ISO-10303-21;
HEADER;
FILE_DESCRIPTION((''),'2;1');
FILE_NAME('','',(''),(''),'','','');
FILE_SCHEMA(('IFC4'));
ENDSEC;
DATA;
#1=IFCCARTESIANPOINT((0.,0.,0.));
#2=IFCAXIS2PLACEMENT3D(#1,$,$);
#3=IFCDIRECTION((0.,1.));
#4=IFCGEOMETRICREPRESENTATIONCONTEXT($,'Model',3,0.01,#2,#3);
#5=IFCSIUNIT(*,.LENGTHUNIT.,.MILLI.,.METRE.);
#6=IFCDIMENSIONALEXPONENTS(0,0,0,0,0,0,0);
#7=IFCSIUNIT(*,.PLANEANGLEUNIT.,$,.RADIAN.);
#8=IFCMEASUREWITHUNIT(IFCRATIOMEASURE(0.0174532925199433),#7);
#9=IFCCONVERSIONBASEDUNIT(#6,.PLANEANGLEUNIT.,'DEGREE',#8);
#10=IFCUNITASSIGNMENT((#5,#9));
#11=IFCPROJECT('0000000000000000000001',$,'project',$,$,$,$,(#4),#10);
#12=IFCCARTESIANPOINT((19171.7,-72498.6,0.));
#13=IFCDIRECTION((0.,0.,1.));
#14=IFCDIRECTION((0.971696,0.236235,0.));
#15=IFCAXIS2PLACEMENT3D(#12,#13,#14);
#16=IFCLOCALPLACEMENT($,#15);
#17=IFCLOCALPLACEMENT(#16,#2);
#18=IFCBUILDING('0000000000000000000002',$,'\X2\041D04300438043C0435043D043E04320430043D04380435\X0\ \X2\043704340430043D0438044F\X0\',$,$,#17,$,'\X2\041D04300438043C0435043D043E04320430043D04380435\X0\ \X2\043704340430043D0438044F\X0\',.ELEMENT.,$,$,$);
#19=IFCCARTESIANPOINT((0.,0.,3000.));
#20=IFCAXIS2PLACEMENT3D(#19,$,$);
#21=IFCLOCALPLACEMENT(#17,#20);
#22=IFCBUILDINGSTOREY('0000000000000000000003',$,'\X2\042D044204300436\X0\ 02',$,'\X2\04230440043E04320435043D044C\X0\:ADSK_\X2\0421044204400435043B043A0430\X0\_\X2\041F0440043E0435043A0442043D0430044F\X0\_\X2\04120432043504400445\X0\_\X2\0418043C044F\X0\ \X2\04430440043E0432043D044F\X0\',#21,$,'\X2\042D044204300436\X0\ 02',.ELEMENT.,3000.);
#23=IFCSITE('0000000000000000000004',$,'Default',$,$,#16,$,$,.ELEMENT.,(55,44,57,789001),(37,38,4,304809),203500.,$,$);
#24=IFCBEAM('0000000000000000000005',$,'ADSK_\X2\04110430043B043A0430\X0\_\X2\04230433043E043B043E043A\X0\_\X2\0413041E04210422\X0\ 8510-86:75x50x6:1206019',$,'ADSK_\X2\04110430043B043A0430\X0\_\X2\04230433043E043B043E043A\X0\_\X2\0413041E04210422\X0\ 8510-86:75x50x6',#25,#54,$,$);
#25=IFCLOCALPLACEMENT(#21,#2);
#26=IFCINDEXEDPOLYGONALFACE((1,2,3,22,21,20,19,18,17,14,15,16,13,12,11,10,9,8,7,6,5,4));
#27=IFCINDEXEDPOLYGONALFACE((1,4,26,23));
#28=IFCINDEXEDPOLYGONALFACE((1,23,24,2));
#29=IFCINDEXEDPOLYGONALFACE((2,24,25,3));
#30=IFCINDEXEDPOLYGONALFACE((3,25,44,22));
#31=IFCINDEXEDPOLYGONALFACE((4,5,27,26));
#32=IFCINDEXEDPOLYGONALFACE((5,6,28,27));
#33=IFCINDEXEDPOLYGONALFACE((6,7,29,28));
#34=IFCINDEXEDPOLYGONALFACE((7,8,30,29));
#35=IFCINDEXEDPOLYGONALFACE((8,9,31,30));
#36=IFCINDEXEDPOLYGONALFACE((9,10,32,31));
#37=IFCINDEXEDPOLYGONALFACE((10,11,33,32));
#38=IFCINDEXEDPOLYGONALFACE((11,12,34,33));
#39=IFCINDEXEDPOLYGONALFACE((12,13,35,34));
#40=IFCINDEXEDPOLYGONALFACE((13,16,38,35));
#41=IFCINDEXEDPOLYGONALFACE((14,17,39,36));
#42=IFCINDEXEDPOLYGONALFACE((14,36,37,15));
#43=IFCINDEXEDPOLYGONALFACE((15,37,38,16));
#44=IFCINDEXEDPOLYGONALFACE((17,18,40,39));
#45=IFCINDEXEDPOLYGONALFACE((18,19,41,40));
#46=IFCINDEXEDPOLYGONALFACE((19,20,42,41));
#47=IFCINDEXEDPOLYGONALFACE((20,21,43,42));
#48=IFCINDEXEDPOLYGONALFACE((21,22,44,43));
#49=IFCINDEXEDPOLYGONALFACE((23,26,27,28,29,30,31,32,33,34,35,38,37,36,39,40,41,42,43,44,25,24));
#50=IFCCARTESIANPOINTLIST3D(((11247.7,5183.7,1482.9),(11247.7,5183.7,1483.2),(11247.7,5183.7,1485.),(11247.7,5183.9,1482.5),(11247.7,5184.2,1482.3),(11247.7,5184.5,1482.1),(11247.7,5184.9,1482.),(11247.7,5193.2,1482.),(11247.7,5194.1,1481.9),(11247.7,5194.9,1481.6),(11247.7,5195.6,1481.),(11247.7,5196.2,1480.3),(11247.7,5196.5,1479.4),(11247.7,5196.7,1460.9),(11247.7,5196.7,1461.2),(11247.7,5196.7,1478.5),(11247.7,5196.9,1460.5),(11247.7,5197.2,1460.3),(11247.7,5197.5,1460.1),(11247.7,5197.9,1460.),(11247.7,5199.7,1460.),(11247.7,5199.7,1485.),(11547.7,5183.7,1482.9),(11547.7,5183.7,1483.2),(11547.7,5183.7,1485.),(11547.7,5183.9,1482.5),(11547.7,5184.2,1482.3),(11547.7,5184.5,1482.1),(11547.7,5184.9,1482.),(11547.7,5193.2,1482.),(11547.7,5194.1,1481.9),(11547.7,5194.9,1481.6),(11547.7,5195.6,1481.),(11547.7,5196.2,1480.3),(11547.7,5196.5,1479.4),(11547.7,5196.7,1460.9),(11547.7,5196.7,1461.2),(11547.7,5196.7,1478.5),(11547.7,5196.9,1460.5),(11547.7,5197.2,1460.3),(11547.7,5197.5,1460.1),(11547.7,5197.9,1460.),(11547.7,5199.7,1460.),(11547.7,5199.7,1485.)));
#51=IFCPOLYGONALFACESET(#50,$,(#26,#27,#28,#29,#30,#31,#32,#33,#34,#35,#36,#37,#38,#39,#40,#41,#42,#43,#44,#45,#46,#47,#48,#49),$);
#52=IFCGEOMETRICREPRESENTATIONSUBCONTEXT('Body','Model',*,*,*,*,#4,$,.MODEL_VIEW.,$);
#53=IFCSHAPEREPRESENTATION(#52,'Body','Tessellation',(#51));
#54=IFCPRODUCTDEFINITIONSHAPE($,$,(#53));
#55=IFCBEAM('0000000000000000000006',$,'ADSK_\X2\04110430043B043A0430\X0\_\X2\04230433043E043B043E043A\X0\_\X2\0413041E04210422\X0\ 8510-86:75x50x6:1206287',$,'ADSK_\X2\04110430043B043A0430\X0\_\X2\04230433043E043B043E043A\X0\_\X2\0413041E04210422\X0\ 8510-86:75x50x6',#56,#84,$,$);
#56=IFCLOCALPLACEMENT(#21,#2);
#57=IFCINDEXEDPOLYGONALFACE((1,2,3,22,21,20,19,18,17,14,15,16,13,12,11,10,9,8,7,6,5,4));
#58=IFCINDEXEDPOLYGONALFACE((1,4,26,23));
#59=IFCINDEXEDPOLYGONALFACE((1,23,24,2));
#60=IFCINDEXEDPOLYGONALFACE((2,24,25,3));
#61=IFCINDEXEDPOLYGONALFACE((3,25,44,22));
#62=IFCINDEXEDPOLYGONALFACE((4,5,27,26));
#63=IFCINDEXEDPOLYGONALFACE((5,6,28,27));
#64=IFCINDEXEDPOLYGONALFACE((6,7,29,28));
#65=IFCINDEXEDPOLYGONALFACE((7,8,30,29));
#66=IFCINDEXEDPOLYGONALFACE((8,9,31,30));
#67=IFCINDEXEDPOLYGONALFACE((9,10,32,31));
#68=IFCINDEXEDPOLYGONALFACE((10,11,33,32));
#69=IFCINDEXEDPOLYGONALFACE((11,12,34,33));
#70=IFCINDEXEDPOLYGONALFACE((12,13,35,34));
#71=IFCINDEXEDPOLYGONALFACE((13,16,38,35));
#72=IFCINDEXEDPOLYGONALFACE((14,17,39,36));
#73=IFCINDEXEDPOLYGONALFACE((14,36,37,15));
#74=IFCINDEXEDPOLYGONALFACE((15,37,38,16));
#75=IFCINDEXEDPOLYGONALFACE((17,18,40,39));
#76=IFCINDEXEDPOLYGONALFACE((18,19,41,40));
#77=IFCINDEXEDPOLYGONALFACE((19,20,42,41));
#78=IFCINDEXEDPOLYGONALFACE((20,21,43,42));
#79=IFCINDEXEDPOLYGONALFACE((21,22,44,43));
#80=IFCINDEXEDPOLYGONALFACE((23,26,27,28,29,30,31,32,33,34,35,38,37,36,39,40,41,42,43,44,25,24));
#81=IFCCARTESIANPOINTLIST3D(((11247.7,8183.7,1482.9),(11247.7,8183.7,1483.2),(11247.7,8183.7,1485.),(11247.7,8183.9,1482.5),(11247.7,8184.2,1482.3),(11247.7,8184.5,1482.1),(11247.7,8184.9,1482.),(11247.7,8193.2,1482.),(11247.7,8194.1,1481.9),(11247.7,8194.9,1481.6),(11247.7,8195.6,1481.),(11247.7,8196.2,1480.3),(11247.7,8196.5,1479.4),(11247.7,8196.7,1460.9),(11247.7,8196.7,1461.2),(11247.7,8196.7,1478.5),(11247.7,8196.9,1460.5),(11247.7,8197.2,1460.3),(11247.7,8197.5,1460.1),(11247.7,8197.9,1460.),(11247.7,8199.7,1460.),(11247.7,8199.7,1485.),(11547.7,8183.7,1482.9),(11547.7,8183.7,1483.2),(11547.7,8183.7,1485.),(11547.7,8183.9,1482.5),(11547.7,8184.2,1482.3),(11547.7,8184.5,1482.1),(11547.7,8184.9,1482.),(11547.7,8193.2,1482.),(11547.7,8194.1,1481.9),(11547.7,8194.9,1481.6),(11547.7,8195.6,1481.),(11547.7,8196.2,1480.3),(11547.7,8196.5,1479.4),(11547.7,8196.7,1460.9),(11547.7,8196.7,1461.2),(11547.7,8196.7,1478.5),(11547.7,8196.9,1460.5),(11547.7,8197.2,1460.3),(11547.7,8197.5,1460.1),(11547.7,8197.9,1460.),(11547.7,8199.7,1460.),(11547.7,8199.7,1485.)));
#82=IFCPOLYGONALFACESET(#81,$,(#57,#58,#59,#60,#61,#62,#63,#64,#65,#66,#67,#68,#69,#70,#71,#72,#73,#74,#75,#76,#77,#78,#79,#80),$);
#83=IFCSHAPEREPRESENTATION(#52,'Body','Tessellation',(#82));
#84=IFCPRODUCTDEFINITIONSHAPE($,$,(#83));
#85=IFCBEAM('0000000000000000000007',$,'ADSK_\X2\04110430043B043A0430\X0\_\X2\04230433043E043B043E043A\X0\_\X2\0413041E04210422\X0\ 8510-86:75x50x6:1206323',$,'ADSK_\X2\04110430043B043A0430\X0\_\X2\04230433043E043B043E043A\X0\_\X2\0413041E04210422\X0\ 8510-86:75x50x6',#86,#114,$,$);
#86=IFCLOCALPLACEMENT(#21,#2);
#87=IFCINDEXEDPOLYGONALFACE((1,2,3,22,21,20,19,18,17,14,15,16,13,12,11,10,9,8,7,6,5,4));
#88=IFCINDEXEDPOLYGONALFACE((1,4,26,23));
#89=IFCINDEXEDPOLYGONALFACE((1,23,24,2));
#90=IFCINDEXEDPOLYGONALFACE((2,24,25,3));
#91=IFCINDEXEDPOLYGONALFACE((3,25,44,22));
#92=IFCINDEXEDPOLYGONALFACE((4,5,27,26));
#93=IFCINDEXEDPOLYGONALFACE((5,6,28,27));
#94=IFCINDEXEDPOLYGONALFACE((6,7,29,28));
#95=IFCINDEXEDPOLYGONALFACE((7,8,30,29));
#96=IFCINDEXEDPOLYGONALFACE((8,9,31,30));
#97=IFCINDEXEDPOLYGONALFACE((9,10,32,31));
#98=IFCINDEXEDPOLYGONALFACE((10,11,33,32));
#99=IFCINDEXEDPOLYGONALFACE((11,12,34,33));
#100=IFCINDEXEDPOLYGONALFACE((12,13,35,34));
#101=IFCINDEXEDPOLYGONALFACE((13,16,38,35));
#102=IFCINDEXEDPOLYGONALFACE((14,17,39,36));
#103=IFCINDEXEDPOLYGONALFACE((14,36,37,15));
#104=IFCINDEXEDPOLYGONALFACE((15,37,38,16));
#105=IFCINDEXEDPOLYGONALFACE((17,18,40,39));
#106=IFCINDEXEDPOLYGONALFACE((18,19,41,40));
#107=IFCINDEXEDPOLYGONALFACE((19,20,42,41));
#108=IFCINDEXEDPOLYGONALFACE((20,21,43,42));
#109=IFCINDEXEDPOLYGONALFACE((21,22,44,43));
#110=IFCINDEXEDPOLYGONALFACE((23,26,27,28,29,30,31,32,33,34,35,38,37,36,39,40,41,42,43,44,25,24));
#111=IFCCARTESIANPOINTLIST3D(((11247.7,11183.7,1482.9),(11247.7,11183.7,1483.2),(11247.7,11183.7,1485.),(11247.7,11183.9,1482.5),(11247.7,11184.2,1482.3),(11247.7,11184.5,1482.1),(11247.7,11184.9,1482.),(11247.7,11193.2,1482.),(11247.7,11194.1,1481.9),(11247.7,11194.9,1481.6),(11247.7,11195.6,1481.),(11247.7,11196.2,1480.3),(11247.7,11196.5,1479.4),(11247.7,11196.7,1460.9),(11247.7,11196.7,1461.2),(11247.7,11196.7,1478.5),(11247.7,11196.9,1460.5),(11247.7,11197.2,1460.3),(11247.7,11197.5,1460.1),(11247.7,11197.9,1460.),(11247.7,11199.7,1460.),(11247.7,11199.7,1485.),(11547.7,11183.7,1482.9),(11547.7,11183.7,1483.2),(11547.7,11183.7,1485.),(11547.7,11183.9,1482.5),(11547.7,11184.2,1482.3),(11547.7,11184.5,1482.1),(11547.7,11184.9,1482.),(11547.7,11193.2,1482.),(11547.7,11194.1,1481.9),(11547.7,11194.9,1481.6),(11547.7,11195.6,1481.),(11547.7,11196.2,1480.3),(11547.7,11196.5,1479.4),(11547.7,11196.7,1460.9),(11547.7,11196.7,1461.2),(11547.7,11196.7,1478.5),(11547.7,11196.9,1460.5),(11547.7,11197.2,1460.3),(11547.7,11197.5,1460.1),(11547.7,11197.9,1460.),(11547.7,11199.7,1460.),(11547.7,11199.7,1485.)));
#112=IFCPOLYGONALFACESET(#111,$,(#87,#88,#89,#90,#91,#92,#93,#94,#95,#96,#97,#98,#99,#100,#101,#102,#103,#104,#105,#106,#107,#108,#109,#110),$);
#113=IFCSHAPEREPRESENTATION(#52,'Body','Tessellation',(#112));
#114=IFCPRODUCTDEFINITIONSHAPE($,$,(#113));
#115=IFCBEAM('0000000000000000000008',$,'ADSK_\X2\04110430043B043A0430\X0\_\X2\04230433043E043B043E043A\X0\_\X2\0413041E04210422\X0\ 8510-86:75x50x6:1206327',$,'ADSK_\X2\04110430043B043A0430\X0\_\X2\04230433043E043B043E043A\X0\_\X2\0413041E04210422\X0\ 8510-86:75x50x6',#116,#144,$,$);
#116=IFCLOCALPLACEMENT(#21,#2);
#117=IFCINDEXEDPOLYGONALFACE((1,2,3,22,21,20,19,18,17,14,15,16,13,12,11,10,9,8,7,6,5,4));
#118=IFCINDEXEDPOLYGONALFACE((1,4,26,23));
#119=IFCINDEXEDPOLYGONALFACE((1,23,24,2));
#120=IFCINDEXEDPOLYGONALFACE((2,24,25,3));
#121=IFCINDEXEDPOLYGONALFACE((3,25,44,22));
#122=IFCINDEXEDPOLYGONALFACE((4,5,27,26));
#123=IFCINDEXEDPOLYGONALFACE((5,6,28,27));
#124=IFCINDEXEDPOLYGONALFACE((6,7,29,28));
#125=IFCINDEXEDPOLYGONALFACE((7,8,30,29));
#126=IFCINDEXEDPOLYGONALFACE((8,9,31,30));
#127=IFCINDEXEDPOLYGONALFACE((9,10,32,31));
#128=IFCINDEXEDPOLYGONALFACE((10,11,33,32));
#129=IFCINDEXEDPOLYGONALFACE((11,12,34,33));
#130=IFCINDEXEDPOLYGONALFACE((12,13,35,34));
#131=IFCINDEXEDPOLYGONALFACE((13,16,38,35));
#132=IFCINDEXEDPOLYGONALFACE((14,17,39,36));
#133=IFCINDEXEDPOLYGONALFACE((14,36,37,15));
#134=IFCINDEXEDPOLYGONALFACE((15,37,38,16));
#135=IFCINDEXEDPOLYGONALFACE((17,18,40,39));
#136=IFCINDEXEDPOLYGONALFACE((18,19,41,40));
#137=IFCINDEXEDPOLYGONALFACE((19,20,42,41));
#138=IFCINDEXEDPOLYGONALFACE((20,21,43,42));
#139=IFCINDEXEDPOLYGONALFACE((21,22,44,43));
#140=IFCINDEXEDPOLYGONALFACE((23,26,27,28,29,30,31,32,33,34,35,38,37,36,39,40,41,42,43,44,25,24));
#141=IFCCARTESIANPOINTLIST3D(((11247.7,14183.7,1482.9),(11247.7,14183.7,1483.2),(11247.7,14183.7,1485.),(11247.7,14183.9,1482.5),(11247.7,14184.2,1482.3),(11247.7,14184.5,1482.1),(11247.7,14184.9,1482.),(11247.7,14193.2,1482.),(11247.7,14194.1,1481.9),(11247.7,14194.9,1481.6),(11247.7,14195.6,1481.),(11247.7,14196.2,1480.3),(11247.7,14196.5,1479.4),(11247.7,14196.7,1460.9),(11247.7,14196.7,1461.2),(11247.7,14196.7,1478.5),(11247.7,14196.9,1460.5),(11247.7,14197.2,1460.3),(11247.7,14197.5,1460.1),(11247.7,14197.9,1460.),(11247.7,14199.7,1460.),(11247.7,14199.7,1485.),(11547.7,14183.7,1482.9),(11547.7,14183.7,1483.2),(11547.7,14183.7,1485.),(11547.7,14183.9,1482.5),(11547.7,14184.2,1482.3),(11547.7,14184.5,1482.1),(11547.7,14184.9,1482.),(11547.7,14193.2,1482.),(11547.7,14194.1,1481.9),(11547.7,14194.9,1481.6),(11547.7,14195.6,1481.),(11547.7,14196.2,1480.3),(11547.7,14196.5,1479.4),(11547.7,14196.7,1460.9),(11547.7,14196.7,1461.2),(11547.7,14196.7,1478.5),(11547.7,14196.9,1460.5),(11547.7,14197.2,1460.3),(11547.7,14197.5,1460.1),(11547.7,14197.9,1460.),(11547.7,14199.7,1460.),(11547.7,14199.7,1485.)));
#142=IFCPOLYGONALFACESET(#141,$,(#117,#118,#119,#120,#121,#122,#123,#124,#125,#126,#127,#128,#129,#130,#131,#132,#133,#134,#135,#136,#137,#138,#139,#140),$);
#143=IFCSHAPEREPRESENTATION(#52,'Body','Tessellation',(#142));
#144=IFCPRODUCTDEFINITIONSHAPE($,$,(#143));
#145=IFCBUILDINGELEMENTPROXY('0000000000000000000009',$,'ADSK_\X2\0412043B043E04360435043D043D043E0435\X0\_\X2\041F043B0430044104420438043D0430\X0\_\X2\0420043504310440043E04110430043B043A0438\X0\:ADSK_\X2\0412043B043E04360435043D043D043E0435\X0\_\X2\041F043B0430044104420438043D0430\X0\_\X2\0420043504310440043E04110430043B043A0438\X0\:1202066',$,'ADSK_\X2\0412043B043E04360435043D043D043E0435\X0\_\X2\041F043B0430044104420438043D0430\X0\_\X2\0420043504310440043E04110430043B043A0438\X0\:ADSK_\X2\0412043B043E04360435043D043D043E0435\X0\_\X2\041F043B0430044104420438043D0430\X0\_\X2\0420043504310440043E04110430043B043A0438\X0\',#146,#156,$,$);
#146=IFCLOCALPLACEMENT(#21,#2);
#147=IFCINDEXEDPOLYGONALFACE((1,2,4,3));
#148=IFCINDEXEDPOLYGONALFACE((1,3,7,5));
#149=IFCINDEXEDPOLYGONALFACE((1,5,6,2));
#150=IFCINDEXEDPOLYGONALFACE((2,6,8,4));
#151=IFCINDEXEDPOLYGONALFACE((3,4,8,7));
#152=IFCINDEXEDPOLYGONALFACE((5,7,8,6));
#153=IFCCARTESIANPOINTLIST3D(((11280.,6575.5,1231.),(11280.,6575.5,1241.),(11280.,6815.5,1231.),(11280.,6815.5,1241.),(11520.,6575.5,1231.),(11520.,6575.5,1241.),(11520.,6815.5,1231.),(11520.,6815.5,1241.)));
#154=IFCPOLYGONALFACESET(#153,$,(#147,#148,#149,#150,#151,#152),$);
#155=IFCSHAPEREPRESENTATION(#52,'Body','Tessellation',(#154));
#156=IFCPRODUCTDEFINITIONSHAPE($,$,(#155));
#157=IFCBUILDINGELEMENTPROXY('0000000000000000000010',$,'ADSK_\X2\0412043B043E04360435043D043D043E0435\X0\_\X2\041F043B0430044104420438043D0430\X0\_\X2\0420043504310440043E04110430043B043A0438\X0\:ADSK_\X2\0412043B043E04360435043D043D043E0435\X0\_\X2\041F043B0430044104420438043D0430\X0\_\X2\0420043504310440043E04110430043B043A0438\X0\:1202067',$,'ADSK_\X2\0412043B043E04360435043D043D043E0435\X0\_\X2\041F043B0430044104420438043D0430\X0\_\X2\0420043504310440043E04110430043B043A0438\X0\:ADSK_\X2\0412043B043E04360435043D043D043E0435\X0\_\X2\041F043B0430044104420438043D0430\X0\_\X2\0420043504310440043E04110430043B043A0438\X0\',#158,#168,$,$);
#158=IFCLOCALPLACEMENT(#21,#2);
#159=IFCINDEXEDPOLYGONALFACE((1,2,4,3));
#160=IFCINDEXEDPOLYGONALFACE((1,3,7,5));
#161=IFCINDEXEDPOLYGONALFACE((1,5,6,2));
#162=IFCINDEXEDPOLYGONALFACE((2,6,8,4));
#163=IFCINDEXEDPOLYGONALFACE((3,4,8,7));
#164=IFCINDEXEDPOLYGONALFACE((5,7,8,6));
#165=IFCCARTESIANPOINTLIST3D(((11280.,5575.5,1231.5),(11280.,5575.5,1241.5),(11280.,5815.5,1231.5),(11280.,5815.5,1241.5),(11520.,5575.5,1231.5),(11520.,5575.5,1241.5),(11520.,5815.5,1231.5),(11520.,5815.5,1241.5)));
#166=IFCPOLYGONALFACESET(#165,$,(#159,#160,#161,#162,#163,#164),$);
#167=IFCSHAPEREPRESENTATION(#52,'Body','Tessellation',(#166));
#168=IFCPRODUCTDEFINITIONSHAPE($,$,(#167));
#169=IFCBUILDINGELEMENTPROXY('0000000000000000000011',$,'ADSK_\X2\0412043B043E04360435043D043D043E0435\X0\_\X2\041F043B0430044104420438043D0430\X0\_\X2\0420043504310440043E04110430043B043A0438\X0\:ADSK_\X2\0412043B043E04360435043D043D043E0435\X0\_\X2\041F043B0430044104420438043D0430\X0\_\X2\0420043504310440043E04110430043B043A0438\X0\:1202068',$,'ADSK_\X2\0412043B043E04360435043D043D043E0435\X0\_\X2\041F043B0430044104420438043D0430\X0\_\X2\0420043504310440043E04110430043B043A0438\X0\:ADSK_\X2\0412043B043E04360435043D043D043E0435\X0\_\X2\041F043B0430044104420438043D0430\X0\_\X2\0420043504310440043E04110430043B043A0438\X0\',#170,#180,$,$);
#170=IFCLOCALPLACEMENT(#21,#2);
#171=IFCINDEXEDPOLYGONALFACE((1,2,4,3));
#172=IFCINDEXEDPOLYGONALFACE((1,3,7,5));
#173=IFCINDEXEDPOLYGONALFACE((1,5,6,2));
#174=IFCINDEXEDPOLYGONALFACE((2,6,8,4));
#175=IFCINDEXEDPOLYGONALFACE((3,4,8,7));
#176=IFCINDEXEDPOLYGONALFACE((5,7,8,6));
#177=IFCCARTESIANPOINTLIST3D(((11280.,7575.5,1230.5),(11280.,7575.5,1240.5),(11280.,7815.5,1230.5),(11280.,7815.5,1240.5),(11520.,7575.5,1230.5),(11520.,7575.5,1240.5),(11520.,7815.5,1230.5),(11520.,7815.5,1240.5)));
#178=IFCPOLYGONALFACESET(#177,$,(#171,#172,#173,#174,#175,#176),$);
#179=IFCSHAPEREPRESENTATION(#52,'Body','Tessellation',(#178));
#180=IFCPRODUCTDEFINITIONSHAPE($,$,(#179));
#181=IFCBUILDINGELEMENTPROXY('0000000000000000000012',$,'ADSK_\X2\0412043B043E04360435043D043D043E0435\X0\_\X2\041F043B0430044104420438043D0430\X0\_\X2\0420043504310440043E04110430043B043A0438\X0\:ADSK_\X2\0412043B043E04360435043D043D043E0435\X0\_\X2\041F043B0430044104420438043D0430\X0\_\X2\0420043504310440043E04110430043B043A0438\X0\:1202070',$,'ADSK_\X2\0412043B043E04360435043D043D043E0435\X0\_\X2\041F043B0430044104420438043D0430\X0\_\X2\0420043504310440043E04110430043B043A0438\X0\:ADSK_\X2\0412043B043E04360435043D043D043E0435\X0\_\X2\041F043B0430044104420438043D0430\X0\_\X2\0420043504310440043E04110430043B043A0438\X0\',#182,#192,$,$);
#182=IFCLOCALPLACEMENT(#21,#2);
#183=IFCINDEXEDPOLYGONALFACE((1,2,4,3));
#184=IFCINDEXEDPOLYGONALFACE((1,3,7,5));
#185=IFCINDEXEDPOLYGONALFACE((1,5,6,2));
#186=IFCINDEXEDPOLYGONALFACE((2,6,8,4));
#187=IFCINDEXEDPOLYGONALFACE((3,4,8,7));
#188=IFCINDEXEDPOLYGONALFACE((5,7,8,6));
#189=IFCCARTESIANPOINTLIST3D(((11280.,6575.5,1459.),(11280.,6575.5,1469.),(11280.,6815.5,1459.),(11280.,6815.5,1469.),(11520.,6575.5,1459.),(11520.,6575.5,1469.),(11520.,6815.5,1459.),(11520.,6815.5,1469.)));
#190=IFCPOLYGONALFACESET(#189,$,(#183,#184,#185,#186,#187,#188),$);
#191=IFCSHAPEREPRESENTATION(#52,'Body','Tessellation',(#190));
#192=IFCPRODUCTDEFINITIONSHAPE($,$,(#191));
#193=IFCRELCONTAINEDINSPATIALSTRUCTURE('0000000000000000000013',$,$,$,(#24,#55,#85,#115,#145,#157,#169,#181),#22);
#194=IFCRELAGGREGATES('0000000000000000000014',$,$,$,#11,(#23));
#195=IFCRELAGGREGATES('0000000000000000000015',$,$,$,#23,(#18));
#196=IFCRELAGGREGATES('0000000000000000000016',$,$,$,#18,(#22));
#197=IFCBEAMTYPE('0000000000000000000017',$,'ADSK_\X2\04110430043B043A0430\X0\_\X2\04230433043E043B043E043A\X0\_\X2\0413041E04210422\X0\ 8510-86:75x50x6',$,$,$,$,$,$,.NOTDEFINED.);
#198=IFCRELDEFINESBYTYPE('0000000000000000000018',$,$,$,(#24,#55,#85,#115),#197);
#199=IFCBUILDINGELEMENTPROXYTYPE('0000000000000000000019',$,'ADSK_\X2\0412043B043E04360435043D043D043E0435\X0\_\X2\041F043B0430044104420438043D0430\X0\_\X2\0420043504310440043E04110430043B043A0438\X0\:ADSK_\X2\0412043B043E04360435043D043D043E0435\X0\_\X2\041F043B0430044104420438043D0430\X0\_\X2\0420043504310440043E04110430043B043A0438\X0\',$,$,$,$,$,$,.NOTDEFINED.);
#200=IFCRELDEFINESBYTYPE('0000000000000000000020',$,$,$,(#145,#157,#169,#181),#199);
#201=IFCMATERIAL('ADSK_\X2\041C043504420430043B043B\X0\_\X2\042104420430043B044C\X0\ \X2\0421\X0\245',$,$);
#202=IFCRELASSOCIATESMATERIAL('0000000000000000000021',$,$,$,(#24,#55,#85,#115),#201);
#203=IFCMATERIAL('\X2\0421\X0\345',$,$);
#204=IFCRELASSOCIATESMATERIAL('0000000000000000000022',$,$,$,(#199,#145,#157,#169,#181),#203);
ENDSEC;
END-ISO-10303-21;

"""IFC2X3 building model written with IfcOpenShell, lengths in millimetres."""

from ifc_helpers import new_model, entity, si_unit, converted_unit, direction, frame, frame_2d, origin, origin_2d_with_axis, place, context, subcontext, project, spatial, polyline, circle_curve, parameter, trimmed, segment, composite_curve, rectangle, outline, extrude, source, transform, mapped, material, type_object, type_shapes, element, save


model = new_model("IFC2X3")

# Units and contexts
model_context = context("Model", 3, precision=0.01, world=origin(), true_north=direction((0.0, 1.0)))
body_context = subcontext(model_context, "Body", "Model", "MODEL_VIEW")
ifc_project = project(units=[si_unit("LENGTHUNIT", "METRE", prefix="MILLI"), converted_unit("PLANEANGLEUNIT", "DEGREE", entity("IfcRatioMeasure", 0.0174532925199433), si_unit("PLANEANGLEUNIT", "RADIAN"), dimensions=[0, 0, 0, 0, 0, 0, 0])], contexts=[model_context])

# Site, building, storey
site_placement = place(None, frame((19171.7, -72498.6, 0.0), z_axis=(0.0, 0.0, 1.0), x_axis=(0.971696, 0.236235, 0.0)))
site = spatial("IfcSite", under=ifc_project, at=site_placement, Name="Default", CompositionType="ELEMENT", RefLatitude=(55, 44, 57, 789001), RefLongitude=(37, 38, 4, 304809), RefElevation=203500.0)
building_placement = place(site_placement, origin())
building = spatial("IfcBuilding", under=site, at=building_placement, Name="Наименование здания", LongName="Наименование здания", CompositionType="ELEMENT")
storey_placement = place(building_placement, frame((0.0, 0.0, 3000.0)))
storey = spatial("IfcBuildingStorey", under=building, at=storey_placement, Name="Этаж 02", ObjectType="Уровень:ADSK_Стрелка_Проектная_Вверх_Имя уровня", LongName="Этаж 02", CompositionType="ELEMENT", Elevation=3000.0)

# Beams
ifc_material_1 = material(Name="С345")
ifc_material_2 = material(Name="ADSK_Металл_Сталь С245")
beam_type_1 = type_object("IfcBeamType", Name="ADSK_Балка_Уголок_ГОСТ 8510-86:75x50x6", PredefinedType="NOTDEFINED")
beam_1_placement = place(storey_placement, frame((11247.7, 5195.5, 1460.0)))
element("IfcBeam", 1, at=beam_1_placement, inside=storey, type_object=beam_type_1, material=ifc_material_2, Name="ADSK_Балка_Уголок_ГОСТ 8510-86:75x50x6:1206019", ObjectType="ADSK_Балка_Уголок_ГОСТ 8510-86:75x50x6", context=body_context, shape_type="SweptSolid", body=[
    extrude(outline(composite_curve([segment(polyline([(-9.8, -9.2), (-8.0, -9.2)]), True, "CONTINUOUS"), segment(trimmed(circle_curve(frame_2d((-8.0, -8.0), x_axis=(0.0, -1.0)), 1.2), [parameter(0.0)], [parameter(90.0)], True, "PARAMETER"), True, "CONTINUOUS"), segment(polyline([(-6.8, -8.0), (-6.8, 0.3)]), True, "CONTINUOUS"), segment(trimmed(circle_curve(frame_2d((-3.3, 0.3), x_axis=(-1.0, 0.0)), 3.5), [parameter(270.0)], [parameter(0.0)], True, "PARAMETER"), False, "CONTINUOUS"), segment(polyline([(-3.3, 3.8), (14.0, 3.8)]), True, "CONTINUOUS"), segment(trimmed(circle_curve(frame_2d((14.0, 5.0), x_axis=(0.0, -1.0)), 1.2), [parameter(0.0)], [parameter(90.0)], True, "PARAMETER"), True, "CONTINUOUS"), segment(polyline([(15.2, 5.0), (15.2, 6.8)]), True, "CONTINUOUS"), segment(polyline([(15.2, 6.8), (-9.8, 6.8)]), True, "CONTINUOUS"), segment(polyline([(-9.8, 6.8), (-9.8, -9.2)]), True, "CONTINUOUS")], self_intersect=False)), frame((0.0, -2.6, 15.2), z_axis=(1.0, 0.0, 0.0), x_axis=(0.0, 0.0, -1.0)), (0.0, 0.0, 1.0), 300.0),
])
beam_2_placement = place(storey_placement, frame((11247.7, 8195.5, 1460.0)))
element("IfcBeam", 2, at=beam_2_placement, inside=storey, type_object=beam_type_1, material=ifc_material_2, Name="ADSK_Балка_Уголок_ГОСТ 8510-86:75x50x6:1206287", ObjectType="ADSK_Балка_Уголок_ГОСТ 8510-86:75x50x6", context=body_context, shape_type="SweptSolid", body=[
    extrude(outline(composite_curve([segment(polyline([(-9.8, -9.2), (-8.0, -9.2)]), True, "CONTINUOUS"), segment(trimmed(circle_curve(frame_2d((-8.0, -8.0), x_axis=(0.0, -1.0)), 1.2), [parameter(0.0)], [parameter(90.0)], True, "PARAMETER"), True, "CONTINUOUS"), segment(polyline([(-6.8, -8.0), (-6.8, 0.3)]), True, "CONTINUOUS"), segment(trimmed(circle_curve(frame_2d((-3.3, 0.3), x_axis=(-1.0, 0.0)), 3.5), [parameter(270.0)], [parameter(0.0)], True, "PARAMETER"), False, "CONTINUOUS"), segment(polyline([(-3.3, 3.8), (14.0, 3.8)]), True, "CONTINUOUS"), segment(trimmed(circle_curve(frame_2d((14.0, 5.0), x_axis=(0.0, -1.0)), 1.2), [parameter(0.0)], [parameter(90.0)], True, "PARAMETER"), True, "CONTINUOUS"), segment(polyline([(15.2, 5.0), (15.2, 6.8)]), True, "CONTINUOUS"), segment(polyline([(15.2, 6.8), (-9.8, 6.8)]), True, "CONTINUOUS"), segment(polyline([(-9.8, 6.8), (-9.8, -9.2)]), True, "CONTINUOUS")], self_intersect=False)), frame((0.0, -2.6, 15.2), z_axis=(1.0, 0.0, 0.0), x_axis=(0.0, 0.0, -1.0)), (0.0, 0.0, 1.0), 300.0),
])
for number, where, name in (
    (3, (11247.7, 11195.5, 1460.0), "ADSK_Балка_Уголок_ГОСТ 8510-86:75x50x6:1206323"),
    (4, (11247.7, 14195.5, 1460.0), "ADSK_Балка_Уголок_ГОСТ 8510-86:75x50x6:1206327"),
):
    element("IfcBeam", number, at=place(storey_placement, frame(where)), inside=storey, type_object=beam_type_1, material=ifc_material_2, Name=name, ObjectType="ADSK_Балка_Уголок_ГОСТ 8510-86:75x50x6", context=body_context, shape_type="SweptSolid", body=[
        extrude(outline(composite_curve([segment(polyline([(-9.8, -9.2), (-8.0, -9.2)]), True, "CONTINUOUS"), segment(trimmed(circle_curve(frame_2d((-8.0, -8.0), x_axis=(0.0, -1.0)), 1.2), [parameter(0.0)], [parameter(90.0)], True, "PARAMETER"), True, "CONTINUOUS"), segment(polyline([(-6.8, -8.0), (-6.8, 0.3)]), True, "CONTINUOUS"), segment(trimmed(circle_curve(frame_2d((-3.3, 0.3), x_axis=(-1.0, 0.0)), 3.5), [parameter(270.0)], [parameter(0.0)], True, "PARAMETER"), False, "CONTINUOUS"), segment(polyline([(-3.3, 3.8), (14.0, 3.8)]), True, "CONTINUOUS"), segment(trimmed(circle_curve(frame_2d((14.0, 5.0), x_axis=(0.0, -1.0)), 1.2), [parameter(0.0)], [parameter(90.0)], True, "PARAMETER"), True, "CONTINUOUS"), segment(polyline([(15.2, 5.0), (15.2, 6.8)]), True, "CONTINUOUS"), segment(polyline([(15.2, 6.8), (-9.8, 6.8)]), True, "CONTINUOUS"), segment(polyline([(-9.8, 6.8), (-9.8, -9.2)]), True, "CONTINUOUS")], self_intersect=False)), frame((0.0, -2.6, 15.2), z_axis=(1.0, 0.0, 0.0), x_axis=(0.0, 0.0, -1.0)), (0.0, 0.0, 1.0), 300.0),
    ])

# Building element proxies
building_element_proxy_type = type_object("IfcBuildingElementProxyType", Name="ADSK_Вложенное_Пластина_РеброБалки:ADSK_Вложенное_Пластина_РеброБалки", PredefinedType="NOTDEFINED", material=ifc_material_1)
shared_shape_1 = source(origin(), body_context, "Body", "SweptSolid", [
    extrude(rectangle(XDim=10.0, YDim=240.0, at=origin_2d_with_axis()), frame((0.0, 0.0, -120.0), z_axis=(0.0, 0.0, 1.0), x_axis=(0.0, 1.0, 0.0)), (0.0, 0.0, 1.0), 240.0),
])
type_shapes(building_element_proxy_type, [shared_shape_1])
for number, where, z_axis, x_axis, name in (
    (5, (11400.0, 6695.5, 1236.0), (0.0, 1.0, 0.0), (1.0, 0.0, 0.0), "ADSK_Вложенное_Пластина_РеброБалки:ADSK_Вложенное_Пластина_РеброБалки:1202066"),
    (6, (11400.0, 5695.5, 1236.5), (0.0, 1.0, 0.0), (1.0, 0.0, 0.0), "ADSK_Вложенное_Пластина_РеброБалки:ADSK_Вложенное_Пластина_РеброБалки:1202067"),
    (7, (11400.0, 7695.5, 1235.5), (0.0, 1.0, 0.0), (1.0, 0.0, 0.0), "ADSK_Вложенное_Пластина_РеброБалки:ADSK_Вложенное_Пластина_РеброБалки:1202068"),
    (8, (11400.0, 6695.5, 1464.0), (0.0, 1.0, 0.0), (1.0, 0.0, 0.0), "ADSK_Вложенное_Пластина_РеброБалки:ADSK_Вложенное_Пластина_РеброБалки:1202070"),
):
    element("IfcBuildingElementProxy", number, at=place(storey_placement, frame(where, z_axis=z_axis, x_axis=x_axis)), inside=storey, type_object=building_element_proxy_type, material=ifc_material_1, Name=name, ObjectType="ADSK_Вложенное_Пластина_РеброБалки:ADSK_Вложенное_Пластина_РеброБалки", context=body_context, shape_type="MappedRepresentation", body=[
        mapped(shared_shape_1, transform((0.0, 0.0, 0.0), scale=1.0)),
    ])

save(model, "model.ifc")
